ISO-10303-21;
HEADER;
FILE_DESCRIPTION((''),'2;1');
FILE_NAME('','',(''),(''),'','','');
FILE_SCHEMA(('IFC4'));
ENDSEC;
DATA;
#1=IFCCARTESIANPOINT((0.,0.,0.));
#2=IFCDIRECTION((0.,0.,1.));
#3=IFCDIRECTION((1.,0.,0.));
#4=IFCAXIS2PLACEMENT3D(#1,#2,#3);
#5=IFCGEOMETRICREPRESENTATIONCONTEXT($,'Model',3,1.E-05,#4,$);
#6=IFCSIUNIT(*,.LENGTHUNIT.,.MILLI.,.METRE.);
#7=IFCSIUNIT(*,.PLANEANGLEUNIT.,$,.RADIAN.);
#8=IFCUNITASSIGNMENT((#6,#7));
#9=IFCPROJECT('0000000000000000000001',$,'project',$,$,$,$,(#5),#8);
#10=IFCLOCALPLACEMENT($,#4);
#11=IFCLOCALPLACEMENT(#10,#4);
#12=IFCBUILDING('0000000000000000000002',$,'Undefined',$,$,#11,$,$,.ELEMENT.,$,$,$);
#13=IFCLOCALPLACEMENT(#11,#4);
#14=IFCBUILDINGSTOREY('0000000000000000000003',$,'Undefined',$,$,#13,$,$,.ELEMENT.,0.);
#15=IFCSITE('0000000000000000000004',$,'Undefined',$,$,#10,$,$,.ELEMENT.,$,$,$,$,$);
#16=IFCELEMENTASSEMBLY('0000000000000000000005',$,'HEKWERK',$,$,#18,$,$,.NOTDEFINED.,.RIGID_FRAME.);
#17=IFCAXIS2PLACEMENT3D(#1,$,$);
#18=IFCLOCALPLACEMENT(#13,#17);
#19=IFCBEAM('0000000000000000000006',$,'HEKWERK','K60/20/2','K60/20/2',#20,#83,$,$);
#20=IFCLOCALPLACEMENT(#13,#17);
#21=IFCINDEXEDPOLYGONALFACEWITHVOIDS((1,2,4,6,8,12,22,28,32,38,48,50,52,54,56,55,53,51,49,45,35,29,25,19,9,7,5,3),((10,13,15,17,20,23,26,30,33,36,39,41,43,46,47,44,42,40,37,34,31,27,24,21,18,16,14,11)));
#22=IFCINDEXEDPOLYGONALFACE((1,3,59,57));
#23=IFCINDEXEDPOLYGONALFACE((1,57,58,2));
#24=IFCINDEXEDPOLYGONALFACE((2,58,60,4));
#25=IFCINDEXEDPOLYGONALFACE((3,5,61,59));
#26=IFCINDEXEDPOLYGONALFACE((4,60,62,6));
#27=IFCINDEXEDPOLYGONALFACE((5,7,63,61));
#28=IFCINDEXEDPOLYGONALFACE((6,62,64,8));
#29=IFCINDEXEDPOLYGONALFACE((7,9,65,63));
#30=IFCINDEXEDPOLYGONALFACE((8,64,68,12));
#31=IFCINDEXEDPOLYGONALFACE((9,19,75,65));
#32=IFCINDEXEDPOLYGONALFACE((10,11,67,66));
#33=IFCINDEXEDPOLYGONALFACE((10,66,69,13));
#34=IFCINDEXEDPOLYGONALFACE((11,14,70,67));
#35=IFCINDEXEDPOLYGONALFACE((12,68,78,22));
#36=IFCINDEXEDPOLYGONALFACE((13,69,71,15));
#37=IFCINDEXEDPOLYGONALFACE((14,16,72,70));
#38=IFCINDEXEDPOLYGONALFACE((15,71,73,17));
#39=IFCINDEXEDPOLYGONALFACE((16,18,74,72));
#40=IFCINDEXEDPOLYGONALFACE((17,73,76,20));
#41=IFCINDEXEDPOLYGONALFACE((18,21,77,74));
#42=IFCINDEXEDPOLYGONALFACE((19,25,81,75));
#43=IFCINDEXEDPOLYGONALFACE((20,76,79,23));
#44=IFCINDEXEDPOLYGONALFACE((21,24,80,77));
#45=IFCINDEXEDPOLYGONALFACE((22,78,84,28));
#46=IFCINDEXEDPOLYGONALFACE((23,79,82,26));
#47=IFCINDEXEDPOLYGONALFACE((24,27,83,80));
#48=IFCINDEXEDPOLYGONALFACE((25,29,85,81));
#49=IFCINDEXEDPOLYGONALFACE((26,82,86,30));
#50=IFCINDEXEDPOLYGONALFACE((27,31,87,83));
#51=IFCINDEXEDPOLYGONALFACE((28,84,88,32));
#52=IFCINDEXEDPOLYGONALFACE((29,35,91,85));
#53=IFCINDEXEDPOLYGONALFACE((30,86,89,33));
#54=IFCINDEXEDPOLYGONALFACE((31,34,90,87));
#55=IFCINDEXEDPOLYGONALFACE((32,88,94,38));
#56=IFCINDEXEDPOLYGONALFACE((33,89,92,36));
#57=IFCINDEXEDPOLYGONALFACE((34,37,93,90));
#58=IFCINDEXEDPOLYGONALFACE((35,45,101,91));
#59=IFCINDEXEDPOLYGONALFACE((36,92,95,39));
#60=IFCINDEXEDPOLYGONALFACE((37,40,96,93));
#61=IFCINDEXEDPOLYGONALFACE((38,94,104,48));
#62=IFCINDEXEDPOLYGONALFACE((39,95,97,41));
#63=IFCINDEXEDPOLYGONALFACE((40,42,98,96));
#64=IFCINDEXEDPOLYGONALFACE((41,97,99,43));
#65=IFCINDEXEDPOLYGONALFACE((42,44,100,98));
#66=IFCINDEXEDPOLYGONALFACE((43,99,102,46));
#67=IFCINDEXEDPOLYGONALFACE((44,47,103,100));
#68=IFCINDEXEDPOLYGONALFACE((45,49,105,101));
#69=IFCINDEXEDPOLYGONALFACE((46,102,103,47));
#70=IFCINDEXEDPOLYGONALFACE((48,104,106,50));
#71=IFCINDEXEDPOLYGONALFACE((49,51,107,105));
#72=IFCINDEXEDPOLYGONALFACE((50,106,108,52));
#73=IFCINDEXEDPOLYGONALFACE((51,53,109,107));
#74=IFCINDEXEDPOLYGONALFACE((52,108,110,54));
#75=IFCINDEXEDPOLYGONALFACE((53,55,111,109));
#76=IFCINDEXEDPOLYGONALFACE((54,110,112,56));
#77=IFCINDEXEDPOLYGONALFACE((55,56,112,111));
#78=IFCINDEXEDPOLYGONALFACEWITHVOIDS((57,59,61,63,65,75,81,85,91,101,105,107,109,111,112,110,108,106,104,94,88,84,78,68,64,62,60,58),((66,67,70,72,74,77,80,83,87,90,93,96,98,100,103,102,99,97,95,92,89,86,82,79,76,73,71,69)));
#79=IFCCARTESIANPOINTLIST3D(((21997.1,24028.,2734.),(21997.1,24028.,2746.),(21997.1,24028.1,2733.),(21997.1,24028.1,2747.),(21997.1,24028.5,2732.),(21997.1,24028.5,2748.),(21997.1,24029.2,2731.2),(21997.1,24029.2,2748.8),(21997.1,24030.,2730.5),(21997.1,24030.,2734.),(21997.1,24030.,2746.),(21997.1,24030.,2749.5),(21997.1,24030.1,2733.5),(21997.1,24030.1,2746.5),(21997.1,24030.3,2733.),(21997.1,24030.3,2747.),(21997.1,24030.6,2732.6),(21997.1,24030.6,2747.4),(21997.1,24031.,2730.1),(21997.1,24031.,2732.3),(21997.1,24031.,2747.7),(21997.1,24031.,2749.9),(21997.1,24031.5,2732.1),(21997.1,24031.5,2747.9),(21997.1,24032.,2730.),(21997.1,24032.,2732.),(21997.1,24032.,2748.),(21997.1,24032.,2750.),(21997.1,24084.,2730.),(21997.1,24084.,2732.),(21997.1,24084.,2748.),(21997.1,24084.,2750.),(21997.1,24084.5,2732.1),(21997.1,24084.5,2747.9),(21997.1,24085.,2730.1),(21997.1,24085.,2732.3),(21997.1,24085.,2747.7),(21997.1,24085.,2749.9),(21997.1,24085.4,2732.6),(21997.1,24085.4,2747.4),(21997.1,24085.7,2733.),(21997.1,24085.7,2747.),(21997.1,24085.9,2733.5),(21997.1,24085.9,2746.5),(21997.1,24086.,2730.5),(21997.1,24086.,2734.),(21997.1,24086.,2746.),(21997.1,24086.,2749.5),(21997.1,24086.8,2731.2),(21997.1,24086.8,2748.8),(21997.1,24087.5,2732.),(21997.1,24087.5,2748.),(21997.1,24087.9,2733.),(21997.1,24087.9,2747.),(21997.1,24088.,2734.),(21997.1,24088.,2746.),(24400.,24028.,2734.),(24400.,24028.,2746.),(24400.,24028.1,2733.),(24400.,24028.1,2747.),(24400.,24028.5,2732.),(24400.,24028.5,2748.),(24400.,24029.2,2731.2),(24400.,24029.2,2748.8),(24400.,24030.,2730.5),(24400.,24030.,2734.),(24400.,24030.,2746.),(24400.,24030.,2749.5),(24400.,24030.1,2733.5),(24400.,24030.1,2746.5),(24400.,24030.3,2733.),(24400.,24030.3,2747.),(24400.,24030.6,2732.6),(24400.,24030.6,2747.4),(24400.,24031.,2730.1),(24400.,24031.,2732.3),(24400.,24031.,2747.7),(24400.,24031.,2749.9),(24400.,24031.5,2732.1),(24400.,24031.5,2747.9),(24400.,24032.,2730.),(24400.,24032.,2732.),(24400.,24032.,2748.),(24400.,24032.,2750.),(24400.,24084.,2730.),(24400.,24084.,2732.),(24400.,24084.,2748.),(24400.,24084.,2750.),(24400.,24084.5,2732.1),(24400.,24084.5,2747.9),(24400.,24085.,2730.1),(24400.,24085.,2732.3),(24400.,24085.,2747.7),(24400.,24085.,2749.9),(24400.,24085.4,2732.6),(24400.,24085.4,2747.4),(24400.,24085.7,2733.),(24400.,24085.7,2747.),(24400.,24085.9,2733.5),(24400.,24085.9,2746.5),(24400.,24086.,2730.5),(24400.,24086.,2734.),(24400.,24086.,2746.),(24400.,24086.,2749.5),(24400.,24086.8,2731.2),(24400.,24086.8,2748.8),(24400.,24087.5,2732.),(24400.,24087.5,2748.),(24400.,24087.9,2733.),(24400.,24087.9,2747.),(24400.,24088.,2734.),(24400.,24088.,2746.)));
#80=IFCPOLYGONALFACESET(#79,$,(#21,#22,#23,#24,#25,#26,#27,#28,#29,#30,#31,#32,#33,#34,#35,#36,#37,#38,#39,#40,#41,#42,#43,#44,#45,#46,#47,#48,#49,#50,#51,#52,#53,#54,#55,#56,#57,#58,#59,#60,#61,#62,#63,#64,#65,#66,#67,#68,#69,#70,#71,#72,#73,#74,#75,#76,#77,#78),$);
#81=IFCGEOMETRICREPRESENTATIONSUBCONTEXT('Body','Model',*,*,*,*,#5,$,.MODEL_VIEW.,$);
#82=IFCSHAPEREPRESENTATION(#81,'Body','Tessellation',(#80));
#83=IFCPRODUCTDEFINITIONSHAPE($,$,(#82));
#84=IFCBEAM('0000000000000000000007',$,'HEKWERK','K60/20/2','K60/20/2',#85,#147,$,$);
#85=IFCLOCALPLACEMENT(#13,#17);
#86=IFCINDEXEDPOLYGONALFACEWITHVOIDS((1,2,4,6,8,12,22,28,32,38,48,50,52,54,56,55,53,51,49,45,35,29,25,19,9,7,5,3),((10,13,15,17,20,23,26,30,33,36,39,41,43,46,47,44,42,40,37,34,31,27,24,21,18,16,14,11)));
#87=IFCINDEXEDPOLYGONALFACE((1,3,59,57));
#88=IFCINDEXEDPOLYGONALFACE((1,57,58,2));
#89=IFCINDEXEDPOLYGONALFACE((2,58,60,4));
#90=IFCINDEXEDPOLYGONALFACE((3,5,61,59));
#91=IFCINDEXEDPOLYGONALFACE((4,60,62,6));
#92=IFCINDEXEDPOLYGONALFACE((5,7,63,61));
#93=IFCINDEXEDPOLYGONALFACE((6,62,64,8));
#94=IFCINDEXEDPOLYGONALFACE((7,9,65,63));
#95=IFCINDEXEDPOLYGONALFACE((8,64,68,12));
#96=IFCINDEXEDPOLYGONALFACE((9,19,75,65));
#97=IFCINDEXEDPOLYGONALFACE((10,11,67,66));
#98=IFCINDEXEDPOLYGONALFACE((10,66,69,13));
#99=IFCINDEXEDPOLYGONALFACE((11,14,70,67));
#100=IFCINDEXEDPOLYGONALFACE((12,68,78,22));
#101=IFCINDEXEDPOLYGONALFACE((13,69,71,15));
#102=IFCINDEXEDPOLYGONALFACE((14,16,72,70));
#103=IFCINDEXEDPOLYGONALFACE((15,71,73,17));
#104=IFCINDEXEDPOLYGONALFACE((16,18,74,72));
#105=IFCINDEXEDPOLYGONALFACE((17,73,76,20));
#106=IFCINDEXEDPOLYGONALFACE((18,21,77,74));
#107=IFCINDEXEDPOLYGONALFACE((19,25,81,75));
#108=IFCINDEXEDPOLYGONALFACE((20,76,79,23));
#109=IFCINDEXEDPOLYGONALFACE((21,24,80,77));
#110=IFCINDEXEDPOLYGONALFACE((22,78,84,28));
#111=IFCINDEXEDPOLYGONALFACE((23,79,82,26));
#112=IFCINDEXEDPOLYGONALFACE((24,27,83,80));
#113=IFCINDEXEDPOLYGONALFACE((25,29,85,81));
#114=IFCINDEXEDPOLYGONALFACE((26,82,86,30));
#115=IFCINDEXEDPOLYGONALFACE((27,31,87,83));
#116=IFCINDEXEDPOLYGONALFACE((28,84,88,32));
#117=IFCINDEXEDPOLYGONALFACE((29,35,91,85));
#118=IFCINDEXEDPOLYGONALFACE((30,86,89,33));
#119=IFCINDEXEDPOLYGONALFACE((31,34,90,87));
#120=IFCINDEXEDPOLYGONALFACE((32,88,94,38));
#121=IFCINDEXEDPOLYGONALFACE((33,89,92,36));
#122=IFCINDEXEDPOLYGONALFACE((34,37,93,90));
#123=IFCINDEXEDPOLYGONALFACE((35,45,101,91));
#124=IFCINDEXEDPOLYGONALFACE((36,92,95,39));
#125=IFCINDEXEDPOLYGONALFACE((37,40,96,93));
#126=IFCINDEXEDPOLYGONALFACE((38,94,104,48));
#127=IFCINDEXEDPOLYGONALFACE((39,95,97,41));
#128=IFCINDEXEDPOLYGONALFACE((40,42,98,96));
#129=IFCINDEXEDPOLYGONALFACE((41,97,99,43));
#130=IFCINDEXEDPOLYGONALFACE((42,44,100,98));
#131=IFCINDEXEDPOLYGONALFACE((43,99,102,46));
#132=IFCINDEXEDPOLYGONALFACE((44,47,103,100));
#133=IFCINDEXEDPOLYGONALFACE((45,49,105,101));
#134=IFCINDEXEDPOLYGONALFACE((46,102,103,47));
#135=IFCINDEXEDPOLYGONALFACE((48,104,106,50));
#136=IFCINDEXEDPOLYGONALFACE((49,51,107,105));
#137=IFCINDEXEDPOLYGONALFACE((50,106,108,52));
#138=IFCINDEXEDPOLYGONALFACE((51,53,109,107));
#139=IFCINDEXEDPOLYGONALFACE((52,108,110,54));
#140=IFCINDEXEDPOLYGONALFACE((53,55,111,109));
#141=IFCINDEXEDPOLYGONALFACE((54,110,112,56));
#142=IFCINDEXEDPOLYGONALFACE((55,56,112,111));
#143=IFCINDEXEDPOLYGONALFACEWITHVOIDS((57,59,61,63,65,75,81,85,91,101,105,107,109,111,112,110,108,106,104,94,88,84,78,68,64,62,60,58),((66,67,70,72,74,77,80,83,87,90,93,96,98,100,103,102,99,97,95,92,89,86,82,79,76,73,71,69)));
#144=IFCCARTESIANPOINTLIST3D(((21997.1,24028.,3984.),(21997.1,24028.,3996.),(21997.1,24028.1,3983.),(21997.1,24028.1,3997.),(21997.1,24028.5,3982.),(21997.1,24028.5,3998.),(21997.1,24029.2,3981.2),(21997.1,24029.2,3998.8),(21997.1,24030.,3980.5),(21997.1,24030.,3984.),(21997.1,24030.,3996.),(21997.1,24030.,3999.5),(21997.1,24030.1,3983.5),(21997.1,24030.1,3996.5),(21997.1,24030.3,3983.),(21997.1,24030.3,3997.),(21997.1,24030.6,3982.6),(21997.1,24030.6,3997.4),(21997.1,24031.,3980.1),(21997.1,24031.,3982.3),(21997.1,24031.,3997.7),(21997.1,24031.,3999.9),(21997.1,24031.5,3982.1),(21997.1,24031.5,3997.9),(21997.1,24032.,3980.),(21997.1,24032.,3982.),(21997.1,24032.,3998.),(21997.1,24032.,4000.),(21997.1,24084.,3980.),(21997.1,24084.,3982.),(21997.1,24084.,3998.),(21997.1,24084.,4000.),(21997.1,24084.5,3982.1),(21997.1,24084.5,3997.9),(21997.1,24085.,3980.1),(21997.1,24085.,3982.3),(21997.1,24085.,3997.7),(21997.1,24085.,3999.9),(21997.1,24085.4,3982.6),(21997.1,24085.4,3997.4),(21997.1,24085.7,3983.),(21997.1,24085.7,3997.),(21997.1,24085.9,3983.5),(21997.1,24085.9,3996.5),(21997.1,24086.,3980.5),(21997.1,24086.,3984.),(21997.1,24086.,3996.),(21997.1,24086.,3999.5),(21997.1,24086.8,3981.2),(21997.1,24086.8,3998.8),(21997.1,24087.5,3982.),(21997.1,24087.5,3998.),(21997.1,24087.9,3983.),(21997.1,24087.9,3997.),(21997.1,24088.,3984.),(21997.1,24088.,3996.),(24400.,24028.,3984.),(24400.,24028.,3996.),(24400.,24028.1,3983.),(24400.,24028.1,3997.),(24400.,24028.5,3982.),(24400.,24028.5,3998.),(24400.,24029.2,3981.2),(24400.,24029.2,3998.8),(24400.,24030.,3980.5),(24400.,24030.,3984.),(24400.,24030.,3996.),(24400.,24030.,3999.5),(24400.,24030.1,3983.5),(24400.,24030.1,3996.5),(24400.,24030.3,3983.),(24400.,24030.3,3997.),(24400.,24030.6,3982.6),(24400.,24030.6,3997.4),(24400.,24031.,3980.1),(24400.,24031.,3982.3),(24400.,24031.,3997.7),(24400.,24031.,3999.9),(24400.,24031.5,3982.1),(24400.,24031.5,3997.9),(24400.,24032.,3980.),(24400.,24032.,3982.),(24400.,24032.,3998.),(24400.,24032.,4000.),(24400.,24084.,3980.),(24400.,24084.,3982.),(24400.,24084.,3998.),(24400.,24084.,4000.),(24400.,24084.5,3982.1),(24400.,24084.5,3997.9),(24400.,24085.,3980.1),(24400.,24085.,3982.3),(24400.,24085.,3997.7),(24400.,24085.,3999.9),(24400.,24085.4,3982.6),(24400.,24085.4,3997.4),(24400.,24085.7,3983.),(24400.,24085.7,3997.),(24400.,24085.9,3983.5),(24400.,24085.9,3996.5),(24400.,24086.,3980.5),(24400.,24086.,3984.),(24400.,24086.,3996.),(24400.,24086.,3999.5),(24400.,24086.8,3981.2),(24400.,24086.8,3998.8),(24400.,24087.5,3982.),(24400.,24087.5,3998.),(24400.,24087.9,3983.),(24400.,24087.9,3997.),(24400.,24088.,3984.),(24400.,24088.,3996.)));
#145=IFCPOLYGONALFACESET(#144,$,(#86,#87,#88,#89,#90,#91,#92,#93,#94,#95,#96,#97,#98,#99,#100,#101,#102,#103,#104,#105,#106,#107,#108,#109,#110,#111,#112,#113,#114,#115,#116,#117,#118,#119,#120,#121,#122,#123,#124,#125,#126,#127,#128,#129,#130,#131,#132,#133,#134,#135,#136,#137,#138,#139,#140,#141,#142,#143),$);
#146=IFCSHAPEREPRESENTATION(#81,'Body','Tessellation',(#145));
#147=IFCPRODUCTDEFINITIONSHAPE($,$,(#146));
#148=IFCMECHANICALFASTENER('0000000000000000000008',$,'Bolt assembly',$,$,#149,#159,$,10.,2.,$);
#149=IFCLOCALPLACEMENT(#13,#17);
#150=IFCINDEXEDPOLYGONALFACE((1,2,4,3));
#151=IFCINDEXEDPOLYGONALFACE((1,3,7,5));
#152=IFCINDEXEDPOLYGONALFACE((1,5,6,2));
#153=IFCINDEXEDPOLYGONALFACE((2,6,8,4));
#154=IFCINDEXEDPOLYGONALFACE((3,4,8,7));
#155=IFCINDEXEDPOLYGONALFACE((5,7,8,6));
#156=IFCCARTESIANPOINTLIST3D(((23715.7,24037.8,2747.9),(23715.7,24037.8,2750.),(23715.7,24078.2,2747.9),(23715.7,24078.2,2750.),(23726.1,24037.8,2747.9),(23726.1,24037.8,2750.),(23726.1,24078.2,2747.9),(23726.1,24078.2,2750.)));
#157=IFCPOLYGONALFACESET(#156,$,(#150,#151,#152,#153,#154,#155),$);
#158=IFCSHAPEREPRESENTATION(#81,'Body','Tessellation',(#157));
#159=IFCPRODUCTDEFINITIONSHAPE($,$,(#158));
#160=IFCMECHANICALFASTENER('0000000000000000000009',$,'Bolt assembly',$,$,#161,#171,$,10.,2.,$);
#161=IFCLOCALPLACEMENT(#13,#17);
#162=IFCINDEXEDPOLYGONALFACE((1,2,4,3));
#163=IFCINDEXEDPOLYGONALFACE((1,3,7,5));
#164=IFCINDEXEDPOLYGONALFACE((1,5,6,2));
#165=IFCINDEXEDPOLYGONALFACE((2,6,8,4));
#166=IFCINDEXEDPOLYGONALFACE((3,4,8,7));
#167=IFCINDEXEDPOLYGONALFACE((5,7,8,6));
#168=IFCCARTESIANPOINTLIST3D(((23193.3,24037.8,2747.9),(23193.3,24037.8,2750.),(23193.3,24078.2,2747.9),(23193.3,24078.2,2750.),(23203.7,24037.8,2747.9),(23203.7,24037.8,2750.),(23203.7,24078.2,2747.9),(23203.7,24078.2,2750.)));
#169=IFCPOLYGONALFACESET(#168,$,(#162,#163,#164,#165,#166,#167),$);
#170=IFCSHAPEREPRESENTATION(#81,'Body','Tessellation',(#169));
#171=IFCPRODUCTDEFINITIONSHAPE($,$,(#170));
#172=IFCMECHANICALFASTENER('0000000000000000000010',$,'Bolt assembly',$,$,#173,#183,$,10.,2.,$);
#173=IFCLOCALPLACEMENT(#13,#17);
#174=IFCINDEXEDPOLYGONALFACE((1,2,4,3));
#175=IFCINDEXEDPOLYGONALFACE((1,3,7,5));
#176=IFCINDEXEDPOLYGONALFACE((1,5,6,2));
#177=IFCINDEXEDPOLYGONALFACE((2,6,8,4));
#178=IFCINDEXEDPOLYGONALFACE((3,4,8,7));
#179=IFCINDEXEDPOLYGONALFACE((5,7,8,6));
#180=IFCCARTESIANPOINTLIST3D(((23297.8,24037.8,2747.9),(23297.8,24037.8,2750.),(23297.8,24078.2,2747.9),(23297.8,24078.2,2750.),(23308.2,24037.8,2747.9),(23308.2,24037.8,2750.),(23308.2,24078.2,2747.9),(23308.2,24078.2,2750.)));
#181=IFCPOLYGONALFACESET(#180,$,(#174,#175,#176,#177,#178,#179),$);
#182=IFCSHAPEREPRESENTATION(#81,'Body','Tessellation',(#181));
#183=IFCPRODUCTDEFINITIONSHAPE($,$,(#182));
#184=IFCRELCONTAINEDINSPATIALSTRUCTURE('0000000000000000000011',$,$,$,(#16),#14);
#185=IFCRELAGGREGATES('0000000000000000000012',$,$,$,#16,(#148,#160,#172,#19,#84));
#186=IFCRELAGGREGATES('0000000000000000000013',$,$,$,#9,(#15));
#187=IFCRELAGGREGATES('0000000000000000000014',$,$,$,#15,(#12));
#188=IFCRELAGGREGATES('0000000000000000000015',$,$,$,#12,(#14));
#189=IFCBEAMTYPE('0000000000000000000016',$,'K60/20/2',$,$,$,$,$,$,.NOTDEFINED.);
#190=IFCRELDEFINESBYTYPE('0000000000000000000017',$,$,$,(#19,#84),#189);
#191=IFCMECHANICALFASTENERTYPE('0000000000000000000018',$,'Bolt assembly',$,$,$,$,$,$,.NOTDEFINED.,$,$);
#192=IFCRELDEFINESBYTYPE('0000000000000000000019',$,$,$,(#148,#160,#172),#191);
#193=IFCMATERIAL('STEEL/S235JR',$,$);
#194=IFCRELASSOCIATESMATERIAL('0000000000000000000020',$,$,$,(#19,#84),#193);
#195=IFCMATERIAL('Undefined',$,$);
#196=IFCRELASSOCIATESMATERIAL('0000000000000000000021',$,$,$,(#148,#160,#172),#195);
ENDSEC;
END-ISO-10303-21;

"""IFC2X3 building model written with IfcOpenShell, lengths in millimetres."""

from ifc_helpers import new_model, si_unit, frame, origin_with_axes, origin_2d_with_axis, place, context, subcontext, project, spatial, polyline, segment, composite_curve, hollow_rectangle, outline, extrude, source, transform, mapped, material, type_object, element, aggregate, save


model = new_model("IFC2X3")

# Units and contexts
model_context = context("Model", 3, precision=1e-05, world=origin_with_axes())
body_context = subcontext(model_context, "Body", "Model", "MODEL_VIEW")
ifc_project = project(units=[si_unit("LENGTHUNIT", "METRE", prefix="MILLI"), si_unit("PLANEANGLEUNIT", "RADIAN")], contexts=[model_context])

# Site, building, storey
site_placement = place(None, origin_with_axes())
site = spatial("IfcSite", under=ifc_project, at=site_placement, Name="Undefined", CompositionType="ELEMENT")
building_placement = place(site_placement, origin_with_axes())
building = spatial("IfcBuilding", under=site, at=building_placement, Name="Undefined", CompositionType="ELEMENT")
storey_placement = place(building_placement, origin_with_axes())
storey = spatial("IfcBuildingStorey", under=building, at=storey_placement, Name="Undefined", CompositionType="ELEMENT", Elevation=0.0)

# Element assembly, beams, mechanical fasteners
assembly_1_placement = place(storey_placement, origin_with_axes())
assembly_1 = element("IfcElementAssembly", 1, at=assembly_1_placement, inside=storey, Name="HEKWERK", AssemblyPlace="NOTDEFINED", PredefinedType="RIGID_FRAME")
ifc_material_1 = material(Name="STEEL/S235JR")
beam_type_1 = type_object("IfcBeamType", Name="K60/20/2", PredefinedType="NOTDEFINED")
beam_1_placement = place(assembly_1_placement, frame((24400.0, 24058.0, 2740.0), z_axis=(0.0, -1.0, 0.0), x_axis=(-1.0, 0.0, 0.0)))
beam_1 = element("IfcBeam", 2, at=beam_1_placement, type_object=beam_type_1, material=ifc_material_1, Name="HEKWERK", Description="K60/20/2", ObjectType="K60/20/2", context=body_context, shape_type="SweptSolid", body=[
    extrude(hollow_rectangle(XDim=20.0, YDim=60.0, WallThickness=2.0, InnerFilletRadius=2.0, OuterFilletRadius=4.0, at=origin_2d_with_axis()), frame((2402.8, 0.0, 0.0), z_axis=(-1.0, 0.0, 0.0), x_axis=(0.0, -1.0, 0.0)), (0.0, 0.0, 1.0), 2402.8),
])
beam_2_placement = place(assembly_1_placement, frame((24400.0, 24058.0, 3990.0), z_axis=(0.0, -1.0, 0.0), x_axis=(-1.0, 0.0, 0.0)))
beam_2 = element("IfcBeam", 3, at=beam_2_placement, type_object=beam_type_1, material=ifc_material_1, Name="HEKWERK", Description="K60/20/2", ObjectType="K60/20/2", context=body_context, shape_type="SweptSolid", body=[
    extrude(hollow_rectangle(XDim=20.0, YDim=60.0, WallThickness=2.0, InnerFilletRadius=2.0, OuterFilletRadius=4.0, at=origin_2d_with_axis()), frame((2402.8, 0.0, 0.0), z_axis=(-1.0, 0.0, 0.0), x_axis=(0.0, -1.0, 0.0)), (0.0, 0.0, 1.0), 2402.8),
])
ifc_material_2 = material(Name="Undefined")
mechanical_fastener_type = type_object("IfcMechanicalFastenerType", Name="Bolt assembly")
shared_shape_1 = source(origin_with_axes(), body_context, "Body", "SweptSolid", [
    extrude(outline(composite_curve([segment(polyline([(-20.2, 5.2), (20.2, 5.2)]), True, "CONTINUOUS"), segment(polyline([(20.2, 5.2), (20.2, -5.2)]), True, "CONTINUOUS"), segment(polyline([(20.2, -5.2), (-20.2, -5.2)]), True, "CONTINUOUS"), segment(polyline([(-20.2, -5.2), (-20.2, 5.2)]), True, "CONTINUOUS")], self_intersect=False)), frame((0.0, -1.0, 0.0), z_axis=(0.0, 1.0, 0.0), x_axis=(1.0, 0.0, 0.0)), (0.0, 0.0, 1.0), 2.1),
])
mechanical_fastener_1_placement = place(assembly_1_placement, frame((23720.9, 24058.0, 2749.0), z_axis=(-1.0, 0.0, 0.0), x_axis=(0.0, 1.0, 0.0)))
mechanical_fastener_1 = element("IfcMechanicalFastener", 4, at=mechanical_fastener_1_placement, type_object=mechanical_fastener_type, material=ifc_material_2, Name="Bolt assembly", NominalDiameter=10.0, NominalLength=2.0, context=body_context, shape_type="MappedRepresentation", body=[
    mapped(shared_shape_1, transform((0.0, 0.0, 0.0))),
])
shared_shape_2 = source(origin_with_axes(), body_context, "Body", "SweptSolid", [
    extrude(outline(composite_curve([segment(polyline([(-20.2, 5.2), (20.2, 5.2)]), True, "CONTINUOUS"), segment(polyline([(20.2, 5.2), (20.2, -5.2)]), True, "CONTINUOUS"), segment(polyline([(20.2, -5.2), (-20.2, -5.2)]), True, "CONTINUOUS"), segment(polyline([(-20.2, -5.2), (-20.2, 5.2)]), True, "CONTINUOUS")], self_intersect=False)), frame((0.0, -1.0, 0.0), z_axis=(0.0, 1.0, 0.0), x_axis=(1.0, 0.0, 0.0)), (0.0, 0.0, 1.0), 2.1),
])
mechanical_fastener_2_placement = place(assembly_1_placement, frame((23198.5, 24058.0, 2749.0), z_axis=(-1.0, 0.0, 0.0), x_axis=(0.0, 1.0, 0.0)))
mechanical_fastener_2 = element("IfcMechanicalFastener", 5, at=mechanical_fastener_2_placement, type_object=mechanical_fastener_type, material=ifc_material_2, Name="Bolt assembly", NominalDiameter=10.0, NominalLength=2.0, context=body_context, shape_type="MappedRepresentation", body=[
    mapped(shared_shape_2, transform((0.0, 0.0, 0.0))),
])
shared_shape_3 = source(origin_with_axes(), body_context, "Body", "SweptSolid", [
    extrude(outline(composite_curve([segment(polyline([(-20.2, 5.2), (20.2, 5.2)]), True, "CONTINUOUS"), segment(polyline([(20.2, 5.2), (20.2, -5.2)]), True, "CONTINUOUS"), segment(polyline([(20.2, -5.2), (-20.2, -5.2)]), True, "CONTINUOUS"), segment(polyline([(-20.2, -5.2), (-20.2, 5.2)]), True, "CONTINUOUS")], self_intersect=False)), frame((0.0, -1.0, 0.0), z_axis=(0.0, 1.0, 0.0), x_axis=(1.0, 0.0, 0.0)), (0.0, 0.0, 1.0), 2.1),
])
mechanical_fastener_3_placement = place(assembly_1_placement, frame((23303.0, 24058.0, 2749.0), z_axis=(-1.0, 0.0, 0.0), x_axis=(0.0, 1.0, 0.0)))
mechanical_fastener_3 = element("IfcMechanicalFastener", 6, at=mechanical_fastener_3_placement, type_object=mechanical_fastener_type, material=ifc_material_2, Name="Bolt assembly", NominalDiameter=10.0, NominalLength=2.0, context=body_context, shape_type="MappedRepresentation", body=[
    mapped(shared_shape_3, transform((0.0, 0.0, 0.0))),
])

aggregate(assembly_1, [mechanical_fastener_1, mechanical_fastener_2, mechanical_fastener_3, beam_1, beam_2])

save(model, "model.ifc")
